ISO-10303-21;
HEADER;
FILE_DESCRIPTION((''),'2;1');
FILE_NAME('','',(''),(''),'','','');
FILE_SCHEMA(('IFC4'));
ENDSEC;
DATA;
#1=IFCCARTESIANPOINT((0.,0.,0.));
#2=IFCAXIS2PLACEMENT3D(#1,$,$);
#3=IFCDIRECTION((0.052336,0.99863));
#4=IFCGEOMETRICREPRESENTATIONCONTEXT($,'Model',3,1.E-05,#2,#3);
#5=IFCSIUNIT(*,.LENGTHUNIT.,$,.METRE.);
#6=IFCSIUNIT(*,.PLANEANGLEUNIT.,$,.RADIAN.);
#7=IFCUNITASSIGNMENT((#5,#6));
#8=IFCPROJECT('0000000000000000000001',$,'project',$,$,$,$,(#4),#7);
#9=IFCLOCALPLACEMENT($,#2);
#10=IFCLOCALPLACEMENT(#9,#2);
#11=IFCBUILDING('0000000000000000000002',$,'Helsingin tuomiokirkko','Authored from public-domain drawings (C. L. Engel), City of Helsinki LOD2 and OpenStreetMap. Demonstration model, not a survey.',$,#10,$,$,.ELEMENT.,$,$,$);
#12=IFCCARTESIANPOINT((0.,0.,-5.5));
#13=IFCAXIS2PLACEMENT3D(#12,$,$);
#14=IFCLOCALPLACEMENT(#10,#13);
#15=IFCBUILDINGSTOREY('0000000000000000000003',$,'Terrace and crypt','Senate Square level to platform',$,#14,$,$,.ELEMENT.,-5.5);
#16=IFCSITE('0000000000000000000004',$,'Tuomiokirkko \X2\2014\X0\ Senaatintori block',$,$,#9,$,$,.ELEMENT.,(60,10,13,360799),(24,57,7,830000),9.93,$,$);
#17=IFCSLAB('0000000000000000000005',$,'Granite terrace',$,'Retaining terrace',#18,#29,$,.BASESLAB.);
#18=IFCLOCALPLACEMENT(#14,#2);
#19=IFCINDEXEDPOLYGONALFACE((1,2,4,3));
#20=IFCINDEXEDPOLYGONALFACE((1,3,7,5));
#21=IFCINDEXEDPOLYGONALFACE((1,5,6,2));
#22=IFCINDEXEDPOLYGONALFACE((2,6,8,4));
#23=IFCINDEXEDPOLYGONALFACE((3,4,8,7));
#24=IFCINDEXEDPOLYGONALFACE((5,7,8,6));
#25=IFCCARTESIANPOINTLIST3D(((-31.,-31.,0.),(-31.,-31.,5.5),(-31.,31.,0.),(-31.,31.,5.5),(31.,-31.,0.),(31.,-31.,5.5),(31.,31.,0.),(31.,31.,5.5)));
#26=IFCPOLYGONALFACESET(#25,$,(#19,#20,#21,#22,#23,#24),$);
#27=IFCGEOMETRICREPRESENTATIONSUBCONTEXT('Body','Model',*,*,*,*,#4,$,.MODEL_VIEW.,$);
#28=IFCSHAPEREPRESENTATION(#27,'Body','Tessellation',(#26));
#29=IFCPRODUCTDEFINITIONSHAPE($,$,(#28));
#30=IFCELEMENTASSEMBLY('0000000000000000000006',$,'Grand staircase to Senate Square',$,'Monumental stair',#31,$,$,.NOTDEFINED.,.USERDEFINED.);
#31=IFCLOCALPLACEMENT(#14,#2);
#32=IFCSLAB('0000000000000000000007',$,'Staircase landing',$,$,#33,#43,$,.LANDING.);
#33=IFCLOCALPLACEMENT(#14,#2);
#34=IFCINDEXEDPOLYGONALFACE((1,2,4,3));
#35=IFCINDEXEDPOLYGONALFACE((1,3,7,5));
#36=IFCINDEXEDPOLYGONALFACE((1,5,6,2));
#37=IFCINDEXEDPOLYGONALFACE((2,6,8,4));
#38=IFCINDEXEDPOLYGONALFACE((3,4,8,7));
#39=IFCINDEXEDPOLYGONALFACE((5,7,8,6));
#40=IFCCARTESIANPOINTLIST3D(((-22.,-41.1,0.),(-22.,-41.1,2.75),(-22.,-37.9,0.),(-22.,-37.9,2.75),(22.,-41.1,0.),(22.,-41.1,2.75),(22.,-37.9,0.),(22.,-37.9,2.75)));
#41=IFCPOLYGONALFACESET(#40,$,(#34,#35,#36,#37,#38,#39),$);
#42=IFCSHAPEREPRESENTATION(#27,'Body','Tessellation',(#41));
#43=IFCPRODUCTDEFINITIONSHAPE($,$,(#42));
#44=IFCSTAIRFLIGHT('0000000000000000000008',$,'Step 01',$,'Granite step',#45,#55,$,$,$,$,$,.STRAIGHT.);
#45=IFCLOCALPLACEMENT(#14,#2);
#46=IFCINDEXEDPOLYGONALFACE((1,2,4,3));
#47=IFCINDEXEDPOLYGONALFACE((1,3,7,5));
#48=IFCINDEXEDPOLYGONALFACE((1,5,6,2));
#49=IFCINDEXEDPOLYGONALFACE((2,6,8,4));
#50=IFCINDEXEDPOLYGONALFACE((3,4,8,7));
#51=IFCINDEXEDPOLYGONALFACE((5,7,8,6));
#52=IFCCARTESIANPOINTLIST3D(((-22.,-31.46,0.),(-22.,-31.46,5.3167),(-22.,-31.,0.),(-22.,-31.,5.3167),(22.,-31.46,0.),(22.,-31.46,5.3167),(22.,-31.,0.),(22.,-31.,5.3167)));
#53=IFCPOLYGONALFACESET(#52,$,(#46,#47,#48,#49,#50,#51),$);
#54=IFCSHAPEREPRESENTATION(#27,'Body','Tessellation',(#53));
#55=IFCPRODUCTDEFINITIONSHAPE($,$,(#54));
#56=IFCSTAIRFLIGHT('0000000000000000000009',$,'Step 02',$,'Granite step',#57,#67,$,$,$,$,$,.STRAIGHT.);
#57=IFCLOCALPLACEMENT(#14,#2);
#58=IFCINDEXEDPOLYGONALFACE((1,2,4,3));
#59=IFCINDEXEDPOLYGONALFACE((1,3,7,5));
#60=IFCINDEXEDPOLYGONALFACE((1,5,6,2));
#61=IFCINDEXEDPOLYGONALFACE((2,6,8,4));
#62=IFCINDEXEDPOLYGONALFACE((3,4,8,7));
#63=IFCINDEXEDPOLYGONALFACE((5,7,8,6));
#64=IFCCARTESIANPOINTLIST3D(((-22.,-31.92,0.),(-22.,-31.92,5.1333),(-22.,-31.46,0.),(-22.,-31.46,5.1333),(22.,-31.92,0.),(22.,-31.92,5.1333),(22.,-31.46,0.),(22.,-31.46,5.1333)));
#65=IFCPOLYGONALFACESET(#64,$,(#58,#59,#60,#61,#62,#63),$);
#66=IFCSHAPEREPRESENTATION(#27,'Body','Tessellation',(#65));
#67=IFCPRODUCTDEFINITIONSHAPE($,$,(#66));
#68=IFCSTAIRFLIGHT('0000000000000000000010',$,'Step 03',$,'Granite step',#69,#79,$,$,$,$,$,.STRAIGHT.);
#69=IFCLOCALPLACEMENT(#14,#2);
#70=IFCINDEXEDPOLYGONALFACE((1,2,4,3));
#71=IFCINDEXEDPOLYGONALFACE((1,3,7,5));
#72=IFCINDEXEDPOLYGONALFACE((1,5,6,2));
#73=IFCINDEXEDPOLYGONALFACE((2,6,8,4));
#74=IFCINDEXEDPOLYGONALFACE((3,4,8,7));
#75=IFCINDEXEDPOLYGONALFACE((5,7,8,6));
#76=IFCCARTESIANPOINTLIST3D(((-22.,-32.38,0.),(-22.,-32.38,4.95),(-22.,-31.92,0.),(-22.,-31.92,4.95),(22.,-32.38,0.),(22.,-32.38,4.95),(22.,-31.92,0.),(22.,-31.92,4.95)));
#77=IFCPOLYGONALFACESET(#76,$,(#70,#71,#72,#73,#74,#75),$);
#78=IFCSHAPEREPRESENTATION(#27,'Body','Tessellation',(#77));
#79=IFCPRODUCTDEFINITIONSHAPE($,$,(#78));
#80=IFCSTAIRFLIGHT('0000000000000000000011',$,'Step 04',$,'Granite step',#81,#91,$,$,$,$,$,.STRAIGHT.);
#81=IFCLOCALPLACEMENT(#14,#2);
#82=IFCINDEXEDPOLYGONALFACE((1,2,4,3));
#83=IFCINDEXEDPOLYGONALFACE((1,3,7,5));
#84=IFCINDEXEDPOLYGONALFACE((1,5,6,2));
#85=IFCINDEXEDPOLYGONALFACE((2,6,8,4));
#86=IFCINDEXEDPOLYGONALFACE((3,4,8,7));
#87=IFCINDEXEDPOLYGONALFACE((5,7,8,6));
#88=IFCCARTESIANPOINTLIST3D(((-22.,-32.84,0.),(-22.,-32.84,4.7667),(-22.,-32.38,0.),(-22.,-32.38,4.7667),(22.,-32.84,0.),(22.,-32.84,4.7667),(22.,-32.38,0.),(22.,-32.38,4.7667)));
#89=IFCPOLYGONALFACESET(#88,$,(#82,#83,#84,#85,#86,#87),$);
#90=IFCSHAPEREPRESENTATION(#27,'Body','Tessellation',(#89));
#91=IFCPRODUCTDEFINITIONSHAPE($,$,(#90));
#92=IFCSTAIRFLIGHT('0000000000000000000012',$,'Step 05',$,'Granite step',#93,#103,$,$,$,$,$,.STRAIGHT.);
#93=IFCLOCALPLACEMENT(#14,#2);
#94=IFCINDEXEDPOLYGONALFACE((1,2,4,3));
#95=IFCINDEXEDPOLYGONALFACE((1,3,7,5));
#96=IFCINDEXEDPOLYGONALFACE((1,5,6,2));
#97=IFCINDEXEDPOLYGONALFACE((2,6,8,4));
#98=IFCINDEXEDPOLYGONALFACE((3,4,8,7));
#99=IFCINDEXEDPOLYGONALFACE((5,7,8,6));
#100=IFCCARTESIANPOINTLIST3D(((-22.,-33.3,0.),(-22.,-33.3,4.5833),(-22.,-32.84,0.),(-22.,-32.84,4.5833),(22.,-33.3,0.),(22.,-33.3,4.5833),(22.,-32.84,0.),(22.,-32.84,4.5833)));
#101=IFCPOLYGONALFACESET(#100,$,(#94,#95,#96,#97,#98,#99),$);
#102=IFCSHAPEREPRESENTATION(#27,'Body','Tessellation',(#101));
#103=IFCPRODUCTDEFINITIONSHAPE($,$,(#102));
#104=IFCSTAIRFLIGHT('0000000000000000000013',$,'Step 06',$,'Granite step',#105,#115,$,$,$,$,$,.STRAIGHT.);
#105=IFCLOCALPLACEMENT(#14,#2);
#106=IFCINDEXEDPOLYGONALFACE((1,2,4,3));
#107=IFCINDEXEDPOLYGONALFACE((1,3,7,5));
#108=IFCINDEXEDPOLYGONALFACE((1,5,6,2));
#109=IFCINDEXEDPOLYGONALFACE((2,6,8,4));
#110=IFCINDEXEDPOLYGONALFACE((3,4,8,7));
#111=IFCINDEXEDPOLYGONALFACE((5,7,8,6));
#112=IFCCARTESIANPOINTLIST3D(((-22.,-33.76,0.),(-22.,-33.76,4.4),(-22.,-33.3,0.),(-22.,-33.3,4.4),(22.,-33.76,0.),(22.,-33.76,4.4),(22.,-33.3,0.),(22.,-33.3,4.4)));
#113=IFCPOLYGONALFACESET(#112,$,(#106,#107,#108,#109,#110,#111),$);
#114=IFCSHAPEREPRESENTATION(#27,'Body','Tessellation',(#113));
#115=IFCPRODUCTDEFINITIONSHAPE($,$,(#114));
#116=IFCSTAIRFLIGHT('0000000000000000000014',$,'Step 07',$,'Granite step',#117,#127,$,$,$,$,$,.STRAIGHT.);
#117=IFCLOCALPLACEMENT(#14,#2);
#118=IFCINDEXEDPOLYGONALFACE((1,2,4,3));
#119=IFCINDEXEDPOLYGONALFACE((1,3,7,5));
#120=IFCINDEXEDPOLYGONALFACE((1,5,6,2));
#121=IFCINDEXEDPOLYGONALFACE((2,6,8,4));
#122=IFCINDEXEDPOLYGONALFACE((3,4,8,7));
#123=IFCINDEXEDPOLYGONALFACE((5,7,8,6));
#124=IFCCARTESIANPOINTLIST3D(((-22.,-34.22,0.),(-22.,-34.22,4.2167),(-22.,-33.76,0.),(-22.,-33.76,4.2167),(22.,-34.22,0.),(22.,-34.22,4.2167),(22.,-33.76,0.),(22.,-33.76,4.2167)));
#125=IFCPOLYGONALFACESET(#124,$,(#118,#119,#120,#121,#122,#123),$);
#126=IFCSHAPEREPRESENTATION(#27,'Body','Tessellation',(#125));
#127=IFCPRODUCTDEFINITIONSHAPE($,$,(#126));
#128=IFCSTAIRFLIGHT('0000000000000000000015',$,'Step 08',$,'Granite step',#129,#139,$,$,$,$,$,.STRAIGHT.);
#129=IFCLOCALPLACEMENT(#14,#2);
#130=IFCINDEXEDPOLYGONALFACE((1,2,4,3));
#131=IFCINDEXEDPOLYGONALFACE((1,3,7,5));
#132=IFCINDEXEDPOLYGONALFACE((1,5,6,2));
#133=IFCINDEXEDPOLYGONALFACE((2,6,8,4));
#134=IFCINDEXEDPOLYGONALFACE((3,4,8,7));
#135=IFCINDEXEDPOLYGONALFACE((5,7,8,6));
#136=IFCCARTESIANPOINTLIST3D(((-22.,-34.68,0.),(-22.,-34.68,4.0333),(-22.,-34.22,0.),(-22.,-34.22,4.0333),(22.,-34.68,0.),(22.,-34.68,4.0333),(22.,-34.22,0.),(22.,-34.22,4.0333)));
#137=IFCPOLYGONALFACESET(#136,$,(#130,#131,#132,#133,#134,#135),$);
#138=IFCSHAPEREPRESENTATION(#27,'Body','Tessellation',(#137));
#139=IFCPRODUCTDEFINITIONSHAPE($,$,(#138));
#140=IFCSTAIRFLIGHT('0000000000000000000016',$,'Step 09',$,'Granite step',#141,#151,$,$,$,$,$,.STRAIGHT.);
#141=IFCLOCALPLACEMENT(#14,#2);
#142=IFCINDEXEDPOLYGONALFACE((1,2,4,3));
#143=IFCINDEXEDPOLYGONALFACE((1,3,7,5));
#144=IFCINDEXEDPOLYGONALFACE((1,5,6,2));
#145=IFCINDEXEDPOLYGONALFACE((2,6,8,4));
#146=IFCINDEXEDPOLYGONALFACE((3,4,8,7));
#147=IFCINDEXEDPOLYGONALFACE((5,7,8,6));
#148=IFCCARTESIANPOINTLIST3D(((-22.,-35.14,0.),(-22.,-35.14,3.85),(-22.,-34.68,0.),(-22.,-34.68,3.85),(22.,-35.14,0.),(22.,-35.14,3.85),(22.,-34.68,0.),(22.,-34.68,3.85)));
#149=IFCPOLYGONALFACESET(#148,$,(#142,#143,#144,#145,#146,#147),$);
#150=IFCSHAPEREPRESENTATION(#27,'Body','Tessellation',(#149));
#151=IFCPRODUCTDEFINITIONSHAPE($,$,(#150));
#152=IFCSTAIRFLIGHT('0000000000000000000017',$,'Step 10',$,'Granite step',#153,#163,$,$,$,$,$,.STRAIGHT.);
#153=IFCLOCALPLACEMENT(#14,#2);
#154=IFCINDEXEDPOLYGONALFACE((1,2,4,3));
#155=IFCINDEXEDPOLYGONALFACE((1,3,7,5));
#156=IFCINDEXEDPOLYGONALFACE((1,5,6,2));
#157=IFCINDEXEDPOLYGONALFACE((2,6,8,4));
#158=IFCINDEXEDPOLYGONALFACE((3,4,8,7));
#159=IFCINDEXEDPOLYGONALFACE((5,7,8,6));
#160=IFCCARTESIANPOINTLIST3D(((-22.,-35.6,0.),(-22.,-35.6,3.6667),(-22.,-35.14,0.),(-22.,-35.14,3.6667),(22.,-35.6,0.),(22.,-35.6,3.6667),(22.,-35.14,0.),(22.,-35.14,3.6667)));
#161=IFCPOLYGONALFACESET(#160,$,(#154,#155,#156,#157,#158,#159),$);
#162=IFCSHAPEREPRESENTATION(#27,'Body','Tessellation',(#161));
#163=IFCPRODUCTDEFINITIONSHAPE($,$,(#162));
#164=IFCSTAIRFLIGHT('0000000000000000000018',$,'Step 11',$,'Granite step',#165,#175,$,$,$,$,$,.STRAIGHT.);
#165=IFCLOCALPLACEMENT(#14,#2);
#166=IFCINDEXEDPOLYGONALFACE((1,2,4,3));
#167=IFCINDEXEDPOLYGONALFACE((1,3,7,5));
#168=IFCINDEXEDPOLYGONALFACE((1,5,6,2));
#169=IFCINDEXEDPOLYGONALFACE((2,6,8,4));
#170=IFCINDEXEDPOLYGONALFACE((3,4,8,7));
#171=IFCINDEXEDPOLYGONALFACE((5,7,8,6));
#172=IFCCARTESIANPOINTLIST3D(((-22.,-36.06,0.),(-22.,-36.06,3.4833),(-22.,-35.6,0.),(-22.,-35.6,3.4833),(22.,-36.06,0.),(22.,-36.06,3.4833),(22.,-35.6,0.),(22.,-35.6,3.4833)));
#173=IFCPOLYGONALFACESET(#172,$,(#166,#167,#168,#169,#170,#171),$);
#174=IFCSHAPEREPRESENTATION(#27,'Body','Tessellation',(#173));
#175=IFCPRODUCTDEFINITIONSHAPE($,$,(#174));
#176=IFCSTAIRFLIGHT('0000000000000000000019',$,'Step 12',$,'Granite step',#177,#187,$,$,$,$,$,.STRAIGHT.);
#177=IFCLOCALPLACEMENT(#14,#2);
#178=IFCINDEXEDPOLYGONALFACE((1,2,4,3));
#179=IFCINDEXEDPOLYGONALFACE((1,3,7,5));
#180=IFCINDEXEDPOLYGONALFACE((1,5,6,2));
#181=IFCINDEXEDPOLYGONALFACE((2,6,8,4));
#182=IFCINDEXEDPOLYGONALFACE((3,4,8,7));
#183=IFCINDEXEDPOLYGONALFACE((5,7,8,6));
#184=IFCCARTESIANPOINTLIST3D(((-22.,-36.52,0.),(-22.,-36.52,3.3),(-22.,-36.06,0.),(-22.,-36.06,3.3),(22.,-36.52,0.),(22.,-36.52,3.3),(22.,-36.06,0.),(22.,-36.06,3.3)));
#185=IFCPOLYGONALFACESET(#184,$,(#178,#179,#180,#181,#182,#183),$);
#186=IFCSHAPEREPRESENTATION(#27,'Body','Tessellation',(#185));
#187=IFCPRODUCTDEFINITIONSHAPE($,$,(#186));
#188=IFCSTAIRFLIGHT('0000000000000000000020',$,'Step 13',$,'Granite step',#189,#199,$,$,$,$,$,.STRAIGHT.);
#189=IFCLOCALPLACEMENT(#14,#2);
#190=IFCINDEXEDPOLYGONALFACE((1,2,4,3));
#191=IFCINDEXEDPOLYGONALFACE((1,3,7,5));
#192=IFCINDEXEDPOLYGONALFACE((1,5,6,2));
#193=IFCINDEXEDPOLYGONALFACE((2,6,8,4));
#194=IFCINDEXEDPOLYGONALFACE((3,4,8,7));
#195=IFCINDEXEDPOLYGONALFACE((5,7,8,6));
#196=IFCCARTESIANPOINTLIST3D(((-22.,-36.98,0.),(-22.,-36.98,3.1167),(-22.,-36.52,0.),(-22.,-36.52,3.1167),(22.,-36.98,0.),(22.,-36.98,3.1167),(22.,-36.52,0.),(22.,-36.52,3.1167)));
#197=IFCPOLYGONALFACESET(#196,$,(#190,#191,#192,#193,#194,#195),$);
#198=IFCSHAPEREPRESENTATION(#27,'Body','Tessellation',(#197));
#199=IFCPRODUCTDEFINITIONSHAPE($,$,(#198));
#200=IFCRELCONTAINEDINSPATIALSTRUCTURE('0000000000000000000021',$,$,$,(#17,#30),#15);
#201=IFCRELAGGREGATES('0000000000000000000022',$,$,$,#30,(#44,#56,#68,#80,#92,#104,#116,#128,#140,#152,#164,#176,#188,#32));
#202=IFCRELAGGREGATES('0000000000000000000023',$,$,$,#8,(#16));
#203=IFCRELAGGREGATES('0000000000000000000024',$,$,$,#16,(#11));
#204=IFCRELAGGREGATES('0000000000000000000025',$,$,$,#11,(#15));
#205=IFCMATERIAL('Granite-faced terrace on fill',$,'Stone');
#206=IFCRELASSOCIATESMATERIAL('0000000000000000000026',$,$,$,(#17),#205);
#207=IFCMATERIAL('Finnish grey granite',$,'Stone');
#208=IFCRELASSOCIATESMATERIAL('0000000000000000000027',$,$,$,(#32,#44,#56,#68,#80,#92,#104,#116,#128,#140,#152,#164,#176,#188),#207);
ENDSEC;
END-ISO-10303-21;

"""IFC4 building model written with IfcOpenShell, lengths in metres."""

from ifc_helpers import new_model, si_unit, direction, frame, origin, origin_2d_with_axis, place, context, subcontext, project, spatial, rectangle, extrude, material, element, aggregate, save


model = new_model("IFC4")

# Units and contexts
model_context = context("Model", 3, precision=1e-05, world=origin(), true_north=direction((0.052336, 0.99863)))
body_context = subcontext(model_context, "Body", "Model", "MODEL_VIEW")
ifc_project = project(units=[si_unit("LENGTHUNIT", "METRE"), si_unit("PLANEANGLEUNIT", "RADIAN")], contexts=[model_context])

# Site, building, storey
site_placement = place(None, origin())
site = spatial("IfcSite", under=ifc_project, at=site_placement, Name="Tuomiokirkko — Senaatintori block", CompositionType="ELEMENT", RefLatitude=(60, 10, 13, 360799), RefLongitude=(24, 57, 7, 830000), RefElevation=9.93)
building_placement = place(site_placement, origin())
building = spatial("IfcBuilding", under=site, at=building_placement, Name="Helsingin tuomiokirkko", Description="Authored from public-domain drawings (C. L. Engel), City of Helsinki LOD2 and OpenStreetMap. Demonstration model, not a survey.", CompositionType="ELEMENT")
storey_placement = place(building_placement, frame((0.0, 0.0, -5.5)))
storey = spatial("IfcBuildingStorey", under=building, at=storey_placement, Name="Terrace and crypt", Description="Senate Square level to platform", CompositionType="ELEMENT", Elevation=-5.5)

# Slab
ifc_material_1 = material(Name="Granite-faced terrace on fill", Category="Stone")
slab_1_placement = place(building_placement, origin())
element("IfcSlab", 1, at=slab_1_placement, inside=storey, material=ifc_material_1, Name="Granite terrace", ObjectType="Retaining terrace", PredefinedType="BASESLAB", context=body_context, shape_type="SweptSolid", body=[
    extrude(rectangle(XDim=62.0, YDim=62.0, at=origin_2d_with_axis()), frame((0.0, 0.0, -5.5)), (0.0, 0.0, 1.0), 5.5),
])

# Element assembly, slab, stair flights
assembly_placement = place(building_placement, origin())
assembly = element("IfcElementAssembly", 2, at=assembly_placement, inside=storey, Name="Grand staircase to Senate Square", ObjectType="Monumental stair", AssemblyPlace="NOTDEFINED", PredefinedType="USERDEFINED")
ifc_material_2 = material(Name="Finnish grey granite", Category="Stone")
slab_2_placement = place(building_placement, origin())
slab_2 = element("IfcSlab", 3, at=slab_2_placement, material=ifc_material_2, Name="Staircase landing", PredefinedType="LANDING", context=body_context, shape_type="SweptSolid", body=[
    extrude(rectangle(XDim=44.0, YDim=3.2, at=origin_2d_with_axis()), frame((0.0, -39.5, -5.5)), (0.0, 0.0, 1.0), 2.75),
])
stair_flight_1_placement = place(building_placement, origin())
stair_flight_1 = element("IfcStairFlight", 4, at=stair_flight_1_placement, material=ifc_material_2, Name="Step 01", ObjectType="Granite step", PredefinedType="STRAIGHT", context=body_context, shape_type="SweptSolid", body=[
    extrude(rectangle(XDim=44.0, YDim=0.46, at=origin_2d_with_axis()), frame((0.0, -31.23, -5.5)), (0.0, 0.0, 1.0), 5.3167),
])
stair_flight_2_placement = place(building_placement, origin())
stair_flight_2 = element("IfcStairFlight", 5, at=stair_flight_2_placement, material=ifc_material_2, Name="Step 02", ObjectType="Granite step", PredefinedType="STRAIGHT", context=body_context, shape_type="SweptSolid", body=[
    extrude(rectangle(XDim=44.0, YDim=0.46, at=origin_2d_with_axis()), frame((0.0, -31.69, -5.5)), (0.0, 0.0, 1.0), 5.1333),
])
stair_flight_3_placement = place(building_placement, origin())
stair_flight_3 = element("IfcStairFlight", 6, at=stair_flight_3_placement, material=ifc_material_2, Name="Step 03", ObjectType="Granite step", PredefinedType="STRAIGHT", context=body_context, shape_type="SweptSolid", body=[
    extrude(rectangle(XDim=44.0, YDim=0.46, at=origin_2d_with_axis()), frame((0.0, -32.15, -5.5)), (0.0, 0.0, 1.0), 4.95),
])
stair_flight_4_placement = place(building_placement, origin())
stair_flight_4 = element("IfcStairFlight", 7, at=stair_flight_4_placement, material=ifc_material_2, Name="Step 04", ObjectType="Granite step", PredefinedType="STRAIGHT", context=body_context, shape_type="SweptSolid", body=[
    extrude(rectangle(XDim=44.0, YDim=0.46, at=origin_2d_with_axis()), frame((0.0, -32.61, -5.5)), (0.0, 0.0, 1.0), 4.7667),
])
stair_flight_5_placement = place(building_placement, origin())
stair_flight_5 = element("IfcStairFlight", 8, at=stair_flight_5_placement, material=ifc_material_2, Name="Step 05", ObjectType="Granite step", PredefinedType="STRAIGHT", context=body_context, shape_type="SweptSolid", body=[
    extrude(rectangle(XDim=44.0, YDim=0.46, at=origin_2d_with_axis()), frame((0.0, -33.07, -5.5)), (0.0, 0.0, 1.0), 4.5833),
])
stair_flight_6_placement = place(building_placement, origin())
stair_flight_6 = element("IfcStairFlight", 9, at=stair_flight_6_placement, material=ifc_material_2, Name="Step 06", ObjectType="Granite step", PredefinedType="STRAIGHT", context=body_context, shape_type="SweptSolid", body=[
    extrude(rectangle(XDim=44.0, YDim=0.46, at=origin_2d_with_axis()), frame((0.0, -33.53, -5.5)), (0.0, 0.0, 1.0), 4.4),
])
stair_flight_7_placement = place(building_placement, origin())
stair_flight_7 = element("IfcStairFlight", 10, at=stair_flight_7_placement, material=ifc_material_2, Name="Step 07", ObjectType="Granite step", PredefinedType="STRAIGHT", context=body_context, shape_type="SweptSolid", body=[
    extrude(rectangle(XDim=44.0, YDim=0.46, at=origin_2d_with_axis()), frame((0.0, -33.99, -5.5)), (0.0, 0.0, 1.0), 4.2167),
])
stair_flight_8_placement = place(building_placement, origin())
stair_flight_8 = element("IfcStairFlight", 11, at=stair_flight_8_placement, material=ifc_material_2, Name="Step 08", ObjectType="Granite step", PredefinedType="STRAIGHT", context=body_context, shape_type="SweptSolid", body=[
    extrude(rectangle(XDim=44.0, YDim=0.46, at=origin_2d_with_axis()), frame((0.0, -34.45, -5.5)), (0.0, 0.0, 1.0), 4.0333),
])
stair_flight_9_placement = place(building_placement, origin())
stair_flight_9 = element("IfcStairFlight", 12, at=stair_flight_9_placement, material=ifc_material_2, Name="Step 09", ObjectType="Granite step", PredefinedType="STRAIGHT", context=body_context, shape_type="SweptSolid", body=[
    extrude(rectangle(XDim=44.0, YDim=0.46, at=origin_2d_with_axis()), frame((0.0, -34.91, -5.5)), (0.0, 0.0, 1.0), 3.85),
])
stair_flight_10_placement = place(building_placement, origin())
stair_flight_10 = element("IfcStairFlight", 13, at=stair_flight_10_placement, material=ifc_material_2, Name="Step 10", ObjectType="Granite step", PredefinedType="STRAIGHT", context=body_context, shape_type="SweptSolid", body=[
    extrude(rectangle(XDim=44.0, YDim=0.46, at=origin_2d_with_axis()), frame((0.0, -35.37, -5.5)), (0.0, 0.0, 1.0), 3.6667),
])
stair_flight_11_placement = place(building_placement, origin())
stair_flight_11 = element("IfcStairFlight", 14, at=stair_flight_11_placement, material=ifc_material_2, Name="Step 11", ObjectType="Granite step", PredefinedType="STRAIGHT", context=body_context, shape_type="SweptSolid", body=[
    extrude(rectangle(XDim=44.0, YDim=0.46, at=origin_2d_with_axis()), frame((0.0, -35.83, -5.5)), (0.0, 0.0, 1.0), 3.4833),
])
stair_flight_12_placement = place(building_placement, origin())
stair_flight_12 = element("IfcStairFlight", 15, at=stair_flight_12_placement, material=ifc_material_2, Name="Step 12", ObjectType="Granite step", PredefinedType="STRAIGHT", context=body_context, shape_type="SweptSolid", body=[
    extrude(rectangle(XDim=44.0, YDim=0.46, at=origin_2d_with_axis()), frame((0.0, -36.29, -5.5)), (0.0, 0.0, 1.0), 3.3),
])
stair_flight_13_placement = place(building_placement, origin())
stair_flight_13 = element("IfcStairFlight", 16, at=stair_flight_13_placement, material=ifc_material_2, Name="Step 13", ObjectType="Granite step", PredefinedType="STRAIGHT", context=body_context, shape_type="SweptSolid", body=[
    extrude(rectangle(XDim=44.0, YDim=0.46, at=origin_2d_with_axis()), frame((0.0, -36.75, -5.5)), (0.0, 0.0, 1.0), 3.1167),
])
aggregate(assembly, [stair_flight_1, stair_flight_2, stair_flight_3, stair_flight_4, stair_flight_5, stair_flight_6, stair_flight_7, stair_flight_8, stair_flight_9, stair_flight_10, stair_flight_11, stair_flight_12, stair_flight_13, slab_2])

save(model, "model.ifc")
